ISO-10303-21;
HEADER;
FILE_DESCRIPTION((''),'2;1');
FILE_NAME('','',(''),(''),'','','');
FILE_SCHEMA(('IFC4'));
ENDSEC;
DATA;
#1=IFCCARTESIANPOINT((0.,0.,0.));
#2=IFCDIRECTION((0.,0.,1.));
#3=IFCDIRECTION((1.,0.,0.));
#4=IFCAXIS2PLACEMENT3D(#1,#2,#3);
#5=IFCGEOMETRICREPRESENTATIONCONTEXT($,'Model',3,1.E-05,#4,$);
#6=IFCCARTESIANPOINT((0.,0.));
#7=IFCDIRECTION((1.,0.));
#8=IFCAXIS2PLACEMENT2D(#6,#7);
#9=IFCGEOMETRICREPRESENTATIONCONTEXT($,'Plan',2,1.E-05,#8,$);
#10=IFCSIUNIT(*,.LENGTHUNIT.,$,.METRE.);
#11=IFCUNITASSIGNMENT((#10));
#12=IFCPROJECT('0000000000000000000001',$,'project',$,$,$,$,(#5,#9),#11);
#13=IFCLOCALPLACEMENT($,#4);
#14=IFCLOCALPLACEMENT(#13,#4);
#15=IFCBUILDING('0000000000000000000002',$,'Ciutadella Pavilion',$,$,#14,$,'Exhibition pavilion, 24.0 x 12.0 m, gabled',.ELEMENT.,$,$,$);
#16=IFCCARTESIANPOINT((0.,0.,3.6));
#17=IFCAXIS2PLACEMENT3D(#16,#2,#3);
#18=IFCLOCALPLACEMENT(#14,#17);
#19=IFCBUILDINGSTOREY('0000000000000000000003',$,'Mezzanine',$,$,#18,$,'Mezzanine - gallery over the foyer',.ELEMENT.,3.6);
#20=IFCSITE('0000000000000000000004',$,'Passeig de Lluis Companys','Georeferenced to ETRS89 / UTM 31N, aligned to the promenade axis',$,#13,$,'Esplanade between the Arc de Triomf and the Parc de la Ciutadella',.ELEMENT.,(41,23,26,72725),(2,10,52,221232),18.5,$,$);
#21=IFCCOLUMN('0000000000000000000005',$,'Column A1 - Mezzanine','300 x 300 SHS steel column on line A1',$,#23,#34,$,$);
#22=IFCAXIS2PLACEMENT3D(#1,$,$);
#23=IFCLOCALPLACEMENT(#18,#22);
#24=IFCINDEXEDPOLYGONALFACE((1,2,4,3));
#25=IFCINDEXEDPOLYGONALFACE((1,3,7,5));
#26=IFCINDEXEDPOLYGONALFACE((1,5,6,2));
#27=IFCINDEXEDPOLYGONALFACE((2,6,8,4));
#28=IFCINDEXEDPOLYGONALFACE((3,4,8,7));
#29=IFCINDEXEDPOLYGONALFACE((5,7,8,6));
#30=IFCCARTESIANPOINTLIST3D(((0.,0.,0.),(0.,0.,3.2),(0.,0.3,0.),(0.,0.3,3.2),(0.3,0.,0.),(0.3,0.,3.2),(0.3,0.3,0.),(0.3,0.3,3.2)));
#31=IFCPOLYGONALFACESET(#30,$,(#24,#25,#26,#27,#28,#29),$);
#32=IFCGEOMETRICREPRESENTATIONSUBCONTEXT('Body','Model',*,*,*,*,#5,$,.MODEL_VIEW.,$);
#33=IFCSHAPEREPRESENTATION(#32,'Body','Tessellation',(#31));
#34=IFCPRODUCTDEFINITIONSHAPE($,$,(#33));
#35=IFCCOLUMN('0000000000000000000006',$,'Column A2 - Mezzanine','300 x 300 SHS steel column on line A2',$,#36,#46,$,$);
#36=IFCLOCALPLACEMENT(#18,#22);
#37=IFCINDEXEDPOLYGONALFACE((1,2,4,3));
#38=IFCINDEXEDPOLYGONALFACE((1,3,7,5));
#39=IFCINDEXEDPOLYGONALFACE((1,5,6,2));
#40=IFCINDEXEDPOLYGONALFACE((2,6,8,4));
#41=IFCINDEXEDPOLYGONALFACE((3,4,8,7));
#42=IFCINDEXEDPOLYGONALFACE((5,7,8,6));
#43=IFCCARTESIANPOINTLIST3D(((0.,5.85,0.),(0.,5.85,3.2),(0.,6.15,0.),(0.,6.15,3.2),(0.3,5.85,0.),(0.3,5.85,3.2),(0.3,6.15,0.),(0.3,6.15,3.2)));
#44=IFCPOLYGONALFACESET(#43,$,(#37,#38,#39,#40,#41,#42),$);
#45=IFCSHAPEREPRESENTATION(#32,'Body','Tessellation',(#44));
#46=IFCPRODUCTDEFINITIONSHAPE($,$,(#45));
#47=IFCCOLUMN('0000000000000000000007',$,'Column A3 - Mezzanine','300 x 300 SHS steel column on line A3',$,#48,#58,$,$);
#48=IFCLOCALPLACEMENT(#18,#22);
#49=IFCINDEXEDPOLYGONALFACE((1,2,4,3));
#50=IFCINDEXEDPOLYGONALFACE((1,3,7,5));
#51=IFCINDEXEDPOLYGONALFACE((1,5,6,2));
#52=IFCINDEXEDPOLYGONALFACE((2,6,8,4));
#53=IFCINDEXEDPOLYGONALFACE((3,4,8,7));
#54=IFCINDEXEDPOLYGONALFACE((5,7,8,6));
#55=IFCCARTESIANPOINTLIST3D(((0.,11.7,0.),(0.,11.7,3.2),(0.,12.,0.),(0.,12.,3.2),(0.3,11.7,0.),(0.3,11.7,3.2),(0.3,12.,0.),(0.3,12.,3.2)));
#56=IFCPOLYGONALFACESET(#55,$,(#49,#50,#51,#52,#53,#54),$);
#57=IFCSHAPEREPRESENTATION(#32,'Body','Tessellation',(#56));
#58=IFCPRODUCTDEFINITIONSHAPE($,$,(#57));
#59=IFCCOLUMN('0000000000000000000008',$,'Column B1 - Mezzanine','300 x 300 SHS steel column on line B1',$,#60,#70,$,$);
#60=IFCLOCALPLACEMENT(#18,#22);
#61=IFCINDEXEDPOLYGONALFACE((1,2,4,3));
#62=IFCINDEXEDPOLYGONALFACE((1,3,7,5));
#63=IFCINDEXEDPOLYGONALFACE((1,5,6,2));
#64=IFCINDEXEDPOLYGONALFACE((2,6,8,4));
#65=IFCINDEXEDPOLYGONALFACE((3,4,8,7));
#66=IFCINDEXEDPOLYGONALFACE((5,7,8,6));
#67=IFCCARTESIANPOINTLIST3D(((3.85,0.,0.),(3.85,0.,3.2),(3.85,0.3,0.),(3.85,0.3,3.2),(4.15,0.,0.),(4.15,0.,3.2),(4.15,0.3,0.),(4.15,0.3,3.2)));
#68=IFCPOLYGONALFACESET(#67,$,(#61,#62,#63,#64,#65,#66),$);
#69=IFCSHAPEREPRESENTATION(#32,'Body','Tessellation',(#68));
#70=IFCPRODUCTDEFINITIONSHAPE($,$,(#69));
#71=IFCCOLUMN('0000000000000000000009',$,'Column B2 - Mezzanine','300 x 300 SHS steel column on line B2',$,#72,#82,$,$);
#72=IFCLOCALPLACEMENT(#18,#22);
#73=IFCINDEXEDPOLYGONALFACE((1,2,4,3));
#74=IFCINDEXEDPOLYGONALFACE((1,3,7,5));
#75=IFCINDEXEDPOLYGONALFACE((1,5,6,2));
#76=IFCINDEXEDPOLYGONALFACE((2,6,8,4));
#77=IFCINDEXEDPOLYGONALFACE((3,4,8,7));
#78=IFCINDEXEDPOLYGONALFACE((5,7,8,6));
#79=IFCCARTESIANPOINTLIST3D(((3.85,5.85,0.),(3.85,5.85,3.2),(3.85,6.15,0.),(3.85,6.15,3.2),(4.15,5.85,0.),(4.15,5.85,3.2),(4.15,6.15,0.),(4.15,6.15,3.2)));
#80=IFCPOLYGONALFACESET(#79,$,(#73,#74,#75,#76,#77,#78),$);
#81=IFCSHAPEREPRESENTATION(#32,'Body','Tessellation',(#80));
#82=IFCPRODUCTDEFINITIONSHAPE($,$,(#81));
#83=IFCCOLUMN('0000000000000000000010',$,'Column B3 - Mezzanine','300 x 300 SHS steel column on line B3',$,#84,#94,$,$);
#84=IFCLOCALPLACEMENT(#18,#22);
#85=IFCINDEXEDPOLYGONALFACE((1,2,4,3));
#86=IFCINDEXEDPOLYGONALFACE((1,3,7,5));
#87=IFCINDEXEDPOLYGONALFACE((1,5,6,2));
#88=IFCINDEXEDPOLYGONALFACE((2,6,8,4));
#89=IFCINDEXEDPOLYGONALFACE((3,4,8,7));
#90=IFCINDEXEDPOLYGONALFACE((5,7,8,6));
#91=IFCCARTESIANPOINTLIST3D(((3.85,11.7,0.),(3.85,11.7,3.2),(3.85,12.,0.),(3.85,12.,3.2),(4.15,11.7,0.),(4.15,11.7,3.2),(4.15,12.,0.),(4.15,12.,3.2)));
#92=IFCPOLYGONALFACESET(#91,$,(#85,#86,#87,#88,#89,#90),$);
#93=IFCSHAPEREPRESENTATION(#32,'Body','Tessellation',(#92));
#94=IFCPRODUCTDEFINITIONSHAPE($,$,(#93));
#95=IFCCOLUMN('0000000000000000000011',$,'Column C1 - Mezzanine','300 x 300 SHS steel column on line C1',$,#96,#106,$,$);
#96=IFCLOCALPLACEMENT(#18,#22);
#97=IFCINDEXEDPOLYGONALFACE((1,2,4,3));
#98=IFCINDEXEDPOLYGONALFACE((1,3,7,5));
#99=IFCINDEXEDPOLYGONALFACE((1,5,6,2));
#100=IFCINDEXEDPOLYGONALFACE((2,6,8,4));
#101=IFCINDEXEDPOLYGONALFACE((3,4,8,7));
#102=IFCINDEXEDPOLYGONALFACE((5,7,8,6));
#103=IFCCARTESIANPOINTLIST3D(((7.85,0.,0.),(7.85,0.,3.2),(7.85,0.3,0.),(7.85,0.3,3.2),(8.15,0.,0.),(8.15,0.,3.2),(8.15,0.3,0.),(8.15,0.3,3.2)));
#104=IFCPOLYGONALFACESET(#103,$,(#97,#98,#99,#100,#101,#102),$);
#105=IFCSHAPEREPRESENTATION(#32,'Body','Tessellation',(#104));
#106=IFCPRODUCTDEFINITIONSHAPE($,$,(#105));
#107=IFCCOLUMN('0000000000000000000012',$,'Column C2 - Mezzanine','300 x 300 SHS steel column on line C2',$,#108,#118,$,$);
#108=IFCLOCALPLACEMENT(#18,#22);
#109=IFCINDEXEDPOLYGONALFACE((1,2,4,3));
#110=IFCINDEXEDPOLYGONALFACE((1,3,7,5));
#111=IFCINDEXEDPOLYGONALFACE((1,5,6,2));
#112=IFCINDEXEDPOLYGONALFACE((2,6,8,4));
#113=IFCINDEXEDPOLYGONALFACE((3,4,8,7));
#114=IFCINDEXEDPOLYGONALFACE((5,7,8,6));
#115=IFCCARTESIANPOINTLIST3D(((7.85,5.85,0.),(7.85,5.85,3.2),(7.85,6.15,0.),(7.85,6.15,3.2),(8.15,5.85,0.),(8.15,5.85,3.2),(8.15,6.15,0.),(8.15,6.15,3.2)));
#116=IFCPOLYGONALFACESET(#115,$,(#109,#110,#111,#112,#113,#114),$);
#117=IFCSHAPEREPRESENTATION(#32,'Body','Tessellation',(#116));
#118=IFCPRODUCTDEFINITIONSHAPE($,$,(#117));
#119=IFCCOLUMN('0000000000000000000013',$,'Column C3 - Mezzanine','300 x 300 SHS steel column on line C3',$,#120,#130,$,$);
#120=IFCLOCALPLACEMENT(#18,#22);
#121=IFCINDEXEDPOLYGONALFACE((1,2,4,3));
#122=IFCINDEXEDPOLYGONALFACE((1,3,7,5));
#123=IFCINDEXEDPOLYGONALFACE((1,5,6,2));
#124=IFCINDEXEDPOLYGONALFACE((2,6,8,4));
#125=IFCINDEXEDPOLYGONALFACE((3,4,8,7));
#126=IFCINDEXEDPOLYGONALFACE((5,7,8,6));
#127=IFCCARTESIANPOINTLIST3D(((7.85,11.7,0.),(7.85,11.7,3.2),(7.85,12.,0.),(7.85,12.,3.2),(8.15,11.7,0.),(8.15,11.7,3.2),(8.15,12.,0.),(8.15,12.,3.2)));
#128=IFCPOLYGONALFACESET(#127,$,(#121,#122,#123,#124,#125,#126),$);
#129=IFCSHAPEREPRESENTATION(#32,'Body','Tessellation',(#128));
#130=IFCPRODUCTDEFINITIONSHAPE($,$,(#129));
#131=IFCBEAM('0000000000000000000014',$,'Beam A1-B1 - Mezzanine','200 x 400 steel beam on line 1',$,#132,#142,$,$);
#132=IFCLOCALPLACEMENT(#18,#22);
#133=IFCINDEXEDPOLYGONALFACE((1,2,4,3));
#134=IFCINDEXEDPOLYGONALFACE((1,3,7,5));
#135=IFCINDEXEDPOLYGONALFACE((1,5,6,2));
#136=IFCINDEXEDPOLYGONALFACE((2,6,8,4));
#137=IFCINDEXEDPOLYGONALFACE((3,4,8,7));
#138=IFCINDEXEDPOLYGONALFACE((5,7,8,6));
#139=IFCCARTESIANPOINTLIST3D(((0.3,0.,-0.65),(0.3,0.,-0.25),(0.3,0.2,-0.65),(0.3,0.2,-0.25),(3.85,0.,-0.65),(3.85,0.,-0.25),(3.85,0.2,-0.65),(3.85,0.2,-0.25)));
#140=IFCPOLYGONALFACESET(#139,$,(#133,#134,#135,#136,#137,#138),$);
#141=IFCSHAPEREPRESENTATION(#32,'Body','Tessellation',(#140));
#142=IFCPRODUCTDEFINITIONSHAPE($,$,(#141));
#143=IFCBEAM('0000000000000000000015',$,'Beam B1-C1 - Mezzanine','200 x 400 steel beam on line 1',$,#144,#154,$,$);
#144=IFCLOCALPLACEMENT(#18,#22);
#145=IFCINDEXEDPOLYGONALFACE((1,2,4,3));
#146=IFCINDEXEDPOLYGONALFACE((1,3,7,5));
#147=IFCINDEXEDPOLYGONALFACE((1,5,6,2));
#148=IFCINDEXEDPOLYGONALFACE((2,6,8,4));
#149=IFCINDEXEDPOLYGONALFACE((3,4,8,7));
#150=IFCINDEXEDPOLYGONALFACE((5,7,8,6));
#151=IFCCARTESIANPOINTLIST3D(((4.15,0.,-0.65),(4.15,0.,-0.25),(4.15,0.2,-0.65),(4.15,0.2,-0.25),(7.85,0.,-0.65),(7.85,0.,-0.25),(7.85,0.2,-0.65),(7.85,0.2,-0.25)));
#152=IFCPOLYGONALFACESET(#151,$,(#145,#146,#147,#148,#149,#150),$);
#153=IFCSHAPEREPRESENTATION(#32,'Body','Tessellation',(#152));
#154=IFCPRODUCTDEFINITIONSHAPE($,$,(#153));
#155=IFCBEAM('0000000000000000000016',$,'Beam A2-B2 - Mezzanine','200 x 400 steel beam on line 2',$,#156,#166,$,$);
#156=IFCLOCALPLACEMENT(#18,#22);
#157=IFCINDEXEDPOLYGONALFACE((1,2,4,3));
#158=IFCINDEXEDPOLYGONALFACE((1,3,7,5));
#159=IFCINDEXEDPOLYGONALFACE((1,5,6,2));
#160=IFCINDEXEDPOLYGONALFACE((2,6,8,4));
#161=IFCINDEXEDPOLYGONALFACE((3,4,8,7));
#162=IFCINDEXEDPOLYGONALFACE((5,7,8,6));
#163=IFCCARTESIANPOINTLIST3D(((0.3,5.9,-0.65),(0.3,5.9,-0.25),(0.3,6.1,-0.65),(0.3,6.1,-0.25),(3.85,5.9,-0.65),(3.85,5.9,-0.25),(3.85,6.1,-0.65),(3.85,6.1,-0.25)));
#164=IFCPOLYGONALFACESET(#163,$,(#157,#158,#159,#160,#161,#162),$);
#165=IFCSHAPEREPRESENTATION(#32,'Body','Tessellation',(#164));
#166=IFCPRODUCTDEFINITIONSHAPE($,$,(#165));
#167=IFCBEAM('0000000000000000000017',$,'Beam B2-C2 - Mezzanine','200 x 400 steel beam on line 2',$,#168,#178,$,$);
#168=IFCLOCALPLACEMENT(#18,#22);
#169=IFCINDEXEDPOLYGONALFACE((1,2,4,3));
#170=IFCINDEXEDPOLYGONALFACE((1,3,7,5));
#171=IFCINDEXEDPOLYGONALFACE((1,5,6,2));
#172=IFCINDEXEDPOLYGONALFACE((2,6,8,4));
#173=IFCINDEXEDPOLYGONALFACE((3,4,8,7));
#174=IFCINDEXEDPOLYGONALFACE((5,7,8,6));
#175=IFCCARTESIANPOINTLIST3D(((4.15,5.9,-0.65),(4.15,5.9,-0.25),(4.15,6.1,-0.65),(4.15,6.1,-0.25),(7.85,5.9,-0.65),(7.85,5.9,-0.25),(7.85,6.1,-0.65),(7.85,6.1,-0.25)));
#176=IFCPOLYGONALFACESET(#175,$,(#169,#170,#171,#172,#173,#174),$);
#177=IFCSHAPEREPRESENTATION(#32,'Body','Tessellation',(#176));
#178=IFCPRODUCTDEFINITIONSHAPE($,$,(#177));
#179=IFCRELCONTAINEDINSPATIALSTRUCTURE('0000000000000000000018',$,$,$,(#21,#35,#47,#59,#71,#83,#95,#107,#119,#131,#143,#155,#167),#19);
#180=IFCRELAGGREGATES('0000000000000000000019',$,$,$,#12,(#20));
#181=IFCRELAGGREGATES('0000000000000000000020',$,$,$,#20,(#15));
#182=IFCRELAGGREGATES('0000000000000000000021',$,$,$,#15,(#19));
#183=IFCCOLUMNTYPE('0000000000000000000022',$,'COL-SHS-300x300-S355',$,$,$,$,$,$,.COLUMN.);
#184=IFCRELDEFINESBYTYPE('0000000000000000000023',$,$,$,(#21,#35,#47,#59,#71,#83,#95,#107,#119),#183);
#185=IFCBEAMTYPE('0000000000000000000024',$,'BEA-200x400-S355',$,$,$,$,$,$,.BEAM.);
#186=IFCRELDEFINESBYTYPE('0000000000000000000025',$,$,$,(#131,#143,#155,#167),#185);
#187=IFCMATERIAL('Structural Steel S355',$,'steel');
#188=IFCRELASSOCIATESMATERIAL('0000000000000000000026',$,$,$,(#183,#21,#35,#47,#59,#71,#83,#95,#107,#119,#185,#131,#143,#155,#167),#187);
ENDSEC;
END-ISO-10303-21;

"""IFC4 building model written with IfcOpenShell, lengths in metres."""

from ifc_helpers import new_model, si_unit, frame, origin_with_axes, origin_2d_with_axis, place, context, subcontext, project, spatial, line, indexed_curve, rectangle, outline, extrude, material, material_profile, profile_set, profile_usage, type_object, element, save


model = new_model("IFC4")

# Units and contexts
model_context = context("Model", 3, precision=1e-05, world=origin_with_axes())
plan_context = context("Plan", 2, precision=1e-05, world=origin_2d_with_axis())
body_context = subcontext(model_context, "Body", "Model", "MODEL_VIEW")
ifc_project = project(units=[si_unit("LENGTHUNIT", "METRE")], contexts=[model_context, plan_context])

# Site, building, storey
site_placement = place(None, origin_with_axes())
site = spatial("IfcSite", under=ifc_project, at=site_placement, Name="Passeig de Lluis Companys", Description="Georeferenced to ETRS89 / UTM 31N, aligned to the promenade axis", LongName="Esplanade between the Arc de Triomf and the Parc de la Ciutadella", CompositionType="ELEMENT", RefLatitude=(41, 23, 26, 72725), RefLongitude=(2, 10, 52, 221232), RefElevation=18.5)
building_placement = place(site_placement, origin_with_axes())
building = spatial("IfcBuilding", under=site, at=building_placement, Name="Ciutadella Pavilion", LongName="Exhibition pavilion, 24.0 x 12.0 m, gabled", CompositionType="ELEMENT")
storey_placement = place(building_placement, frame((0.0, 0.0, 3.6), z_axis=(0.0, 0.0, 1.0), x_axis=(1.0, 0.0, 0.0)))
storey = spatial("IfcBuildingStorey", under=building, at=storey_placement, Name="Mezzanine", LongName="Mezzanine - gallery over the foyer", CompositionType="ELEMENT", Elevation=3.6)

# Columns
ifc_material_1 = material(Name="Structural Steel S355", Category="steel")
ifc_material_profile_1 = material_profile(ifc_material_1, rectangle(XDim=0.3, YDim=0.3))
ifc_profile_set_1 = profile_set([ifc_material_profile_1], Name="COL-SHS-300x300-S355")
ifc_profile_usage_1 = profile_usage(ifc_profile_set_1)
column_type = type_object("IfcColumnType", Name="COL-SHS-300x300-S355", PredefinedType="COLUMN", material=ifc_profile_set_1)
column_1_placement = place(storey_placement, origin_with_axes())
element("IfcColumn", 1, at=column_1_placement, inside=storey, type_object=column_type, material=ifc_profile_usage_1, Name="Column A1 - Mezzanine", Description="300 x 300 SHS steel column on line A1", context=body_context, shape_type="SweptSolid", body=[
    extrude(outline(indexed_curve([(0.0, 0.0), (0.3, 0.0), (0.3, 0.3), (0.0, 0.3)], segments=[line(1, 2, 3, 4, 1)])), origin_with_axes(), (0.0, 0.0, 1.0), 3.2),
])
ifc_profile_usage_2 = profile_usage(ifc_profile_set_1)
column_2_placement = place(storey_placement, frame((0.0, 5.85, 0.0), z_axis=(0.0, 0.0, 1.0), x_axis=(1.0, 0.0, 0.0)))
element("IfcColumn", 2, at=column_2_placement, inside=storey, type_object=column_type, material=ifc_profile_usage_2, Name="Column A2 - Mezzanine", Description="300 x 300 SHS steel column on line A2", context=body_context, shape_type="SweptSolid", body=[
    extrude(outline(indexed_curve([(0.0, 0.0), (0.3, 0.0), (0.3, 0.3), (0.0, 0.3)], segments=[line(1, 2, 3, 4, 1)])), origin_with_axes(), (0.0, 0.0, 1.0), 3.2),
])
ifc_profile_usage_3 = profile_usage(ifc_profile_set_1)
column_3_placement = place(storey_placement, frame((0.0, 11.7, 0.0), z_axis=(0.0, 0.0, 1.0), x_axis=(1.0, 0.0, 0.0)))
element("IfcColumn", 3, at=column_3_placement, inside=storey, type_object=column_type, material=ifc_profile_usage_3, Name="Column A3 - Mezzanine", Description="300 x 300 SHS steel column on line A3", context=body_context, shape_type="SweptSolid", body=[
    extrude(outline(indexed_curve([(0.0, 0.0), (0.3, 0.0), (0.3, 0.3), (0.0, 0.3)], segments=[line(1, 2, 3, 4, 1)])), origin_with_axes(), (0.0, 0.0, 1.0), 3.2),
])
ifc_profile_usage_4 = profile_usage(ifc_profile_set_1)
column_4_placement = place(storey_placement, frame((3.85, 0.0, 0.0), z_axis=(0.0, 0.0, 1.0), x_axis=(1.0, 0.0, 0.0)))
element("IfcColumn", 4, at=column_4_placement, inside=storey, type_object=column_type, material=ifc_profile_usage_4, Name="Column B1 - Mezzanine", Description="300 x 300 SHS steel column on line B1", context=body_context, shape_type="SweptSolid", body=[
    extrude(outline(indexed_curve([(0.0, 0.0), (0.3, 0.0), (0.3, 0.3), (0.0, 0.3)], segments=[line(1, 2, 3, 4, 1)])), origin_with_axes(), (0.0, 0.0, 1.0), 3.2),
])
ifc_profile_usage_5 = profile_usage(ifc_profile_set_1)
column_5_placement = place(storey_placement, frame((3.85, 5.85, 0.0), z_axis=(0.0, 0.0, 1.0), x_axis=(1.0, 0.0, 0.0)))
element("IfcColumn", 5, at=column_5_placement, inside=storey, type_object=column_type, material=ifc_profile_usage_5, Name="Column B2 - Mezzanine", Description="300 x 300 SHS steel column on line B2", context=body_context, shape_type="SweptSolid", body=[
    extrude(outline(indexed_curve([(0.0, 0.0), (0.3, 0.0), (0.3, 0.3), (0.0, 0.3)], segments=[line(1, 2, 3, 4, 1)])), origin_with_axes(), (0.0, 0.0, 1.0), 3.2),
])
ifc_profile_usage_6 = profile_usage(ifc_profile_set_1)
column_6_placement = place(storey_placement, frame((3.85, 11.7, 0.0), z_axis=(0.0, 0.0, 1.0), x_axis=(1.0, 0.0, 0.0)))
element("IfcColumn", 6, at=column_6_placement, inside=storey, type_object=column_type, material=ifc_profile_usage_6, Name="Column B3 - Mezzanine", Description="300 x 300 SHS steel column on line B3", context=body_context, shape_type="SweptSolid", body=[
    extrude(outline(indexed_curve([(0.0, 0.0), (0.3, 0.0), (0.3, 0.3), (0.0, 0.3)], segments=[line(1, 2, 3, 4, 1)])), origin_with_axes(), (0.0, 0.0, 1.0), 3.2),
])
ifc_profile_usage_7 = profile_usage(ifc_profile_set_1)
column_7_placement = place(storey_placement, frame((7.85, 0.0, 0.0), z_axis=(0.0, 0.0, 1.0), x_axis=(1.0, 0.0, 0.0)))
element("IfcColumn", 7, at=column_7_placement, inside=storey, type_object=column_type, material=ifc_profile_usage_7, Name="Column C1 - Mezzanine", Description="300 x 300 SHS steel column on line C1", context=body_context, shape_type="SweptSolid", body=[
    extrude(outline(indexed_curve([(0.0, 0.0), (0.3, 0.0), (0.3, 0.3), (0.0, 0.3)], segments=[line(1, 2, 3, 4, 1)])), origin_with_axes(), (0.0, 0.0, 1.0), 3.2),
])
ifc_profile_usage_8 = profile_usage(ifc_profile_set_1)
column_8_placement = place(storey_placement, frame((7.85, 5.85, 0.0), z_axis=(0.0, 0.0, 1.0), x_axis=(1.0, 0.0, 0.0)))
element("IfcColumn", 8, at=column_8_placement, inside=storey, type_object=column_type, material=ifc_profile_usage_8, Name="Column C2 - Mezzanine", Description="300 x 300 SHS steel column on line C2", context=body_context, shape_type="SweptSolid", body=[
    extrude(outline(indexed_curve([(0.0, 0.0), (0.3, 0.0), (0.3, 0.3), (0.0, 0.3)], segments=[line(1, 2, 3, 4, 1)])), origin_with_axes(), (0.0, 0.0, 1.0), 3.2),
])
ifc_profile_usage_9 = profile_usage(ifc_profile_set_1)
column_9_placement = place(storey_placement, frame((7.85, 11.7, 0.0), z_axis=(0.0, 0.0, 1.0), x_axis=(1.0, 0.0, 0.0)))
element("IfcColumn", 9, at=column_9_placement, inside=storey, type_object=column_type, material=ifc_profile_usage_9, Name="Column C3 - Mezzanine", Description="300 x 300 SHS steel column on line C3", context=body_context, shape_type="SweptSolid", body=[
    extrude(outline(indexed_curve([(0.0, 0.0), (0.3, 0.0), (0.3, 0.3), (0.0, 0.3)], segments=[line(1, 2, 3, 4, 1)])), origin_with_axes(), (0.0, 0.0, 1.0), 3.2),
])

# Beams
ifc_material_profile_2 = material_profile(ifc_material_1, rectangle(XDim=0.2, YDim=0.4))
ifc_profile_set_2 = profile_set([ifc_material_profile_2], Name="BEA-200x400-S355")
ifc_profile_usage_10 = profile_usage(ifc_profile_set_2)
beam_type = type_object("IfcBeamType", Name="BEA-200x400-S355", PredefinedType="BEAM", material=ifc_profile_set_2)
beam_1_placement = place(storey_placement, frame((0.3, 0.0, -0.65), z_axis=(1.0, 0.0, 0.0), x_axis=(0.0, 1.0, 0.0)))
element("IfcBeam", 10, at=beam_1_placement, inside=storey, type_object=beam_type, material=ifc_profile_usage_10, Name="Beam A1-B1 - Mezzanine", Description="200 x 400 steel beam on line 1", context=body_context, shape_type="SweptSolid", body=[
    extrude(outline(indexed_curve([(0.0, 0.0), (0.2, 0.0), (0.2, 0.4), (0.0, 0.4)], segments=[line(1, 2, 3, 4, 1)])), origin_with_axes(), (0.0, 0.0, 1.0), 3.55),
])
ifc_profile_usage_11 = profile_usage(ifc_profile_set_2)
beam_2_placement = place(storey_placement, frame((4.15, 0.0, -0.65), z_axis=(1.0, 0.0, 0.0), x_axis=(0.0, 1.0, 0.0)))
element("IfcBeam", 11, at=beam_2_placement, inside=storey, type_object=beam_type, material=ifc_profile_usage_11, Name="Beam B1-C1 - Mezzanine", Description="200 x 400 steel beam on line 1", context=body_context, shape_type="SweptSolid", body=[
    extrude(outline(indexed_curve([(0.0, 0.0), (0.2, 0.0), (0.2, 0.4), (0.0, 0.4)], segments=[line(1, 2, 3, 4, 1)])), origin_with_axes(), (0.0, 0.0, 1.0), 3.7),
])
ifc_profile_usage_12 = profile_usage(ifc_profile_set_2)
beam_3_placement = place(storey_placement, frame((0.3, 5.9, -0.65), z_axis=(1.0, 0.0, 0.0), x_axis=(0.0, 1.0, 0.0)))
element("IfcBeam", 12, at=beam_3_placement, inside=storey, type_object=beam_type, material=ifc_profile_usage_12, Name="Beam A2-B2 - Mezzanine", Description="200 x 400 steel beam on line 2", context=body_context, shape_type="SweptSolid", body=[
    extrude(outline(indexed_curve([(0.0, 0.0), (0.2, 0.0), (0.2, 0.4), (0.0, 0.4)], segments=[line(1, 2, 3, 4, 1)])), origin_with_axes(), (0.0, 0.0, 1.0), 3.55),
])
ifc_profile_usage_13 = profile_usage(ifc_profile_set_2)
beam_4_placement = place(storey_placement, frame((4.15, 5.9, -0.65), z_axis=(1.0, 0.0, 0.0), x_axis=(0.0, 1.0, 0.0)))
element("IfcBeam", 13, at=beam_4_placement, inside=storey, type_object=beam_type, material=ifc_profile_usage_13, Name="Beam B2-C2 - Mezzanine", Description="200 x 400 steel beam on line 2", context=body_context, shape_type="SweptSolid", body=[
    extrude(outline(indexed_curve([(0.0, 0.0), (0.2, 0.0), (0.2, 0.4), (0.0, 0.4)], segments=[line(1, 2, 3, 4, 1)])), origin_with_axes(), (0.0, 0.0, 1.0), 3.7),
])

save(model, "model.ifc")
